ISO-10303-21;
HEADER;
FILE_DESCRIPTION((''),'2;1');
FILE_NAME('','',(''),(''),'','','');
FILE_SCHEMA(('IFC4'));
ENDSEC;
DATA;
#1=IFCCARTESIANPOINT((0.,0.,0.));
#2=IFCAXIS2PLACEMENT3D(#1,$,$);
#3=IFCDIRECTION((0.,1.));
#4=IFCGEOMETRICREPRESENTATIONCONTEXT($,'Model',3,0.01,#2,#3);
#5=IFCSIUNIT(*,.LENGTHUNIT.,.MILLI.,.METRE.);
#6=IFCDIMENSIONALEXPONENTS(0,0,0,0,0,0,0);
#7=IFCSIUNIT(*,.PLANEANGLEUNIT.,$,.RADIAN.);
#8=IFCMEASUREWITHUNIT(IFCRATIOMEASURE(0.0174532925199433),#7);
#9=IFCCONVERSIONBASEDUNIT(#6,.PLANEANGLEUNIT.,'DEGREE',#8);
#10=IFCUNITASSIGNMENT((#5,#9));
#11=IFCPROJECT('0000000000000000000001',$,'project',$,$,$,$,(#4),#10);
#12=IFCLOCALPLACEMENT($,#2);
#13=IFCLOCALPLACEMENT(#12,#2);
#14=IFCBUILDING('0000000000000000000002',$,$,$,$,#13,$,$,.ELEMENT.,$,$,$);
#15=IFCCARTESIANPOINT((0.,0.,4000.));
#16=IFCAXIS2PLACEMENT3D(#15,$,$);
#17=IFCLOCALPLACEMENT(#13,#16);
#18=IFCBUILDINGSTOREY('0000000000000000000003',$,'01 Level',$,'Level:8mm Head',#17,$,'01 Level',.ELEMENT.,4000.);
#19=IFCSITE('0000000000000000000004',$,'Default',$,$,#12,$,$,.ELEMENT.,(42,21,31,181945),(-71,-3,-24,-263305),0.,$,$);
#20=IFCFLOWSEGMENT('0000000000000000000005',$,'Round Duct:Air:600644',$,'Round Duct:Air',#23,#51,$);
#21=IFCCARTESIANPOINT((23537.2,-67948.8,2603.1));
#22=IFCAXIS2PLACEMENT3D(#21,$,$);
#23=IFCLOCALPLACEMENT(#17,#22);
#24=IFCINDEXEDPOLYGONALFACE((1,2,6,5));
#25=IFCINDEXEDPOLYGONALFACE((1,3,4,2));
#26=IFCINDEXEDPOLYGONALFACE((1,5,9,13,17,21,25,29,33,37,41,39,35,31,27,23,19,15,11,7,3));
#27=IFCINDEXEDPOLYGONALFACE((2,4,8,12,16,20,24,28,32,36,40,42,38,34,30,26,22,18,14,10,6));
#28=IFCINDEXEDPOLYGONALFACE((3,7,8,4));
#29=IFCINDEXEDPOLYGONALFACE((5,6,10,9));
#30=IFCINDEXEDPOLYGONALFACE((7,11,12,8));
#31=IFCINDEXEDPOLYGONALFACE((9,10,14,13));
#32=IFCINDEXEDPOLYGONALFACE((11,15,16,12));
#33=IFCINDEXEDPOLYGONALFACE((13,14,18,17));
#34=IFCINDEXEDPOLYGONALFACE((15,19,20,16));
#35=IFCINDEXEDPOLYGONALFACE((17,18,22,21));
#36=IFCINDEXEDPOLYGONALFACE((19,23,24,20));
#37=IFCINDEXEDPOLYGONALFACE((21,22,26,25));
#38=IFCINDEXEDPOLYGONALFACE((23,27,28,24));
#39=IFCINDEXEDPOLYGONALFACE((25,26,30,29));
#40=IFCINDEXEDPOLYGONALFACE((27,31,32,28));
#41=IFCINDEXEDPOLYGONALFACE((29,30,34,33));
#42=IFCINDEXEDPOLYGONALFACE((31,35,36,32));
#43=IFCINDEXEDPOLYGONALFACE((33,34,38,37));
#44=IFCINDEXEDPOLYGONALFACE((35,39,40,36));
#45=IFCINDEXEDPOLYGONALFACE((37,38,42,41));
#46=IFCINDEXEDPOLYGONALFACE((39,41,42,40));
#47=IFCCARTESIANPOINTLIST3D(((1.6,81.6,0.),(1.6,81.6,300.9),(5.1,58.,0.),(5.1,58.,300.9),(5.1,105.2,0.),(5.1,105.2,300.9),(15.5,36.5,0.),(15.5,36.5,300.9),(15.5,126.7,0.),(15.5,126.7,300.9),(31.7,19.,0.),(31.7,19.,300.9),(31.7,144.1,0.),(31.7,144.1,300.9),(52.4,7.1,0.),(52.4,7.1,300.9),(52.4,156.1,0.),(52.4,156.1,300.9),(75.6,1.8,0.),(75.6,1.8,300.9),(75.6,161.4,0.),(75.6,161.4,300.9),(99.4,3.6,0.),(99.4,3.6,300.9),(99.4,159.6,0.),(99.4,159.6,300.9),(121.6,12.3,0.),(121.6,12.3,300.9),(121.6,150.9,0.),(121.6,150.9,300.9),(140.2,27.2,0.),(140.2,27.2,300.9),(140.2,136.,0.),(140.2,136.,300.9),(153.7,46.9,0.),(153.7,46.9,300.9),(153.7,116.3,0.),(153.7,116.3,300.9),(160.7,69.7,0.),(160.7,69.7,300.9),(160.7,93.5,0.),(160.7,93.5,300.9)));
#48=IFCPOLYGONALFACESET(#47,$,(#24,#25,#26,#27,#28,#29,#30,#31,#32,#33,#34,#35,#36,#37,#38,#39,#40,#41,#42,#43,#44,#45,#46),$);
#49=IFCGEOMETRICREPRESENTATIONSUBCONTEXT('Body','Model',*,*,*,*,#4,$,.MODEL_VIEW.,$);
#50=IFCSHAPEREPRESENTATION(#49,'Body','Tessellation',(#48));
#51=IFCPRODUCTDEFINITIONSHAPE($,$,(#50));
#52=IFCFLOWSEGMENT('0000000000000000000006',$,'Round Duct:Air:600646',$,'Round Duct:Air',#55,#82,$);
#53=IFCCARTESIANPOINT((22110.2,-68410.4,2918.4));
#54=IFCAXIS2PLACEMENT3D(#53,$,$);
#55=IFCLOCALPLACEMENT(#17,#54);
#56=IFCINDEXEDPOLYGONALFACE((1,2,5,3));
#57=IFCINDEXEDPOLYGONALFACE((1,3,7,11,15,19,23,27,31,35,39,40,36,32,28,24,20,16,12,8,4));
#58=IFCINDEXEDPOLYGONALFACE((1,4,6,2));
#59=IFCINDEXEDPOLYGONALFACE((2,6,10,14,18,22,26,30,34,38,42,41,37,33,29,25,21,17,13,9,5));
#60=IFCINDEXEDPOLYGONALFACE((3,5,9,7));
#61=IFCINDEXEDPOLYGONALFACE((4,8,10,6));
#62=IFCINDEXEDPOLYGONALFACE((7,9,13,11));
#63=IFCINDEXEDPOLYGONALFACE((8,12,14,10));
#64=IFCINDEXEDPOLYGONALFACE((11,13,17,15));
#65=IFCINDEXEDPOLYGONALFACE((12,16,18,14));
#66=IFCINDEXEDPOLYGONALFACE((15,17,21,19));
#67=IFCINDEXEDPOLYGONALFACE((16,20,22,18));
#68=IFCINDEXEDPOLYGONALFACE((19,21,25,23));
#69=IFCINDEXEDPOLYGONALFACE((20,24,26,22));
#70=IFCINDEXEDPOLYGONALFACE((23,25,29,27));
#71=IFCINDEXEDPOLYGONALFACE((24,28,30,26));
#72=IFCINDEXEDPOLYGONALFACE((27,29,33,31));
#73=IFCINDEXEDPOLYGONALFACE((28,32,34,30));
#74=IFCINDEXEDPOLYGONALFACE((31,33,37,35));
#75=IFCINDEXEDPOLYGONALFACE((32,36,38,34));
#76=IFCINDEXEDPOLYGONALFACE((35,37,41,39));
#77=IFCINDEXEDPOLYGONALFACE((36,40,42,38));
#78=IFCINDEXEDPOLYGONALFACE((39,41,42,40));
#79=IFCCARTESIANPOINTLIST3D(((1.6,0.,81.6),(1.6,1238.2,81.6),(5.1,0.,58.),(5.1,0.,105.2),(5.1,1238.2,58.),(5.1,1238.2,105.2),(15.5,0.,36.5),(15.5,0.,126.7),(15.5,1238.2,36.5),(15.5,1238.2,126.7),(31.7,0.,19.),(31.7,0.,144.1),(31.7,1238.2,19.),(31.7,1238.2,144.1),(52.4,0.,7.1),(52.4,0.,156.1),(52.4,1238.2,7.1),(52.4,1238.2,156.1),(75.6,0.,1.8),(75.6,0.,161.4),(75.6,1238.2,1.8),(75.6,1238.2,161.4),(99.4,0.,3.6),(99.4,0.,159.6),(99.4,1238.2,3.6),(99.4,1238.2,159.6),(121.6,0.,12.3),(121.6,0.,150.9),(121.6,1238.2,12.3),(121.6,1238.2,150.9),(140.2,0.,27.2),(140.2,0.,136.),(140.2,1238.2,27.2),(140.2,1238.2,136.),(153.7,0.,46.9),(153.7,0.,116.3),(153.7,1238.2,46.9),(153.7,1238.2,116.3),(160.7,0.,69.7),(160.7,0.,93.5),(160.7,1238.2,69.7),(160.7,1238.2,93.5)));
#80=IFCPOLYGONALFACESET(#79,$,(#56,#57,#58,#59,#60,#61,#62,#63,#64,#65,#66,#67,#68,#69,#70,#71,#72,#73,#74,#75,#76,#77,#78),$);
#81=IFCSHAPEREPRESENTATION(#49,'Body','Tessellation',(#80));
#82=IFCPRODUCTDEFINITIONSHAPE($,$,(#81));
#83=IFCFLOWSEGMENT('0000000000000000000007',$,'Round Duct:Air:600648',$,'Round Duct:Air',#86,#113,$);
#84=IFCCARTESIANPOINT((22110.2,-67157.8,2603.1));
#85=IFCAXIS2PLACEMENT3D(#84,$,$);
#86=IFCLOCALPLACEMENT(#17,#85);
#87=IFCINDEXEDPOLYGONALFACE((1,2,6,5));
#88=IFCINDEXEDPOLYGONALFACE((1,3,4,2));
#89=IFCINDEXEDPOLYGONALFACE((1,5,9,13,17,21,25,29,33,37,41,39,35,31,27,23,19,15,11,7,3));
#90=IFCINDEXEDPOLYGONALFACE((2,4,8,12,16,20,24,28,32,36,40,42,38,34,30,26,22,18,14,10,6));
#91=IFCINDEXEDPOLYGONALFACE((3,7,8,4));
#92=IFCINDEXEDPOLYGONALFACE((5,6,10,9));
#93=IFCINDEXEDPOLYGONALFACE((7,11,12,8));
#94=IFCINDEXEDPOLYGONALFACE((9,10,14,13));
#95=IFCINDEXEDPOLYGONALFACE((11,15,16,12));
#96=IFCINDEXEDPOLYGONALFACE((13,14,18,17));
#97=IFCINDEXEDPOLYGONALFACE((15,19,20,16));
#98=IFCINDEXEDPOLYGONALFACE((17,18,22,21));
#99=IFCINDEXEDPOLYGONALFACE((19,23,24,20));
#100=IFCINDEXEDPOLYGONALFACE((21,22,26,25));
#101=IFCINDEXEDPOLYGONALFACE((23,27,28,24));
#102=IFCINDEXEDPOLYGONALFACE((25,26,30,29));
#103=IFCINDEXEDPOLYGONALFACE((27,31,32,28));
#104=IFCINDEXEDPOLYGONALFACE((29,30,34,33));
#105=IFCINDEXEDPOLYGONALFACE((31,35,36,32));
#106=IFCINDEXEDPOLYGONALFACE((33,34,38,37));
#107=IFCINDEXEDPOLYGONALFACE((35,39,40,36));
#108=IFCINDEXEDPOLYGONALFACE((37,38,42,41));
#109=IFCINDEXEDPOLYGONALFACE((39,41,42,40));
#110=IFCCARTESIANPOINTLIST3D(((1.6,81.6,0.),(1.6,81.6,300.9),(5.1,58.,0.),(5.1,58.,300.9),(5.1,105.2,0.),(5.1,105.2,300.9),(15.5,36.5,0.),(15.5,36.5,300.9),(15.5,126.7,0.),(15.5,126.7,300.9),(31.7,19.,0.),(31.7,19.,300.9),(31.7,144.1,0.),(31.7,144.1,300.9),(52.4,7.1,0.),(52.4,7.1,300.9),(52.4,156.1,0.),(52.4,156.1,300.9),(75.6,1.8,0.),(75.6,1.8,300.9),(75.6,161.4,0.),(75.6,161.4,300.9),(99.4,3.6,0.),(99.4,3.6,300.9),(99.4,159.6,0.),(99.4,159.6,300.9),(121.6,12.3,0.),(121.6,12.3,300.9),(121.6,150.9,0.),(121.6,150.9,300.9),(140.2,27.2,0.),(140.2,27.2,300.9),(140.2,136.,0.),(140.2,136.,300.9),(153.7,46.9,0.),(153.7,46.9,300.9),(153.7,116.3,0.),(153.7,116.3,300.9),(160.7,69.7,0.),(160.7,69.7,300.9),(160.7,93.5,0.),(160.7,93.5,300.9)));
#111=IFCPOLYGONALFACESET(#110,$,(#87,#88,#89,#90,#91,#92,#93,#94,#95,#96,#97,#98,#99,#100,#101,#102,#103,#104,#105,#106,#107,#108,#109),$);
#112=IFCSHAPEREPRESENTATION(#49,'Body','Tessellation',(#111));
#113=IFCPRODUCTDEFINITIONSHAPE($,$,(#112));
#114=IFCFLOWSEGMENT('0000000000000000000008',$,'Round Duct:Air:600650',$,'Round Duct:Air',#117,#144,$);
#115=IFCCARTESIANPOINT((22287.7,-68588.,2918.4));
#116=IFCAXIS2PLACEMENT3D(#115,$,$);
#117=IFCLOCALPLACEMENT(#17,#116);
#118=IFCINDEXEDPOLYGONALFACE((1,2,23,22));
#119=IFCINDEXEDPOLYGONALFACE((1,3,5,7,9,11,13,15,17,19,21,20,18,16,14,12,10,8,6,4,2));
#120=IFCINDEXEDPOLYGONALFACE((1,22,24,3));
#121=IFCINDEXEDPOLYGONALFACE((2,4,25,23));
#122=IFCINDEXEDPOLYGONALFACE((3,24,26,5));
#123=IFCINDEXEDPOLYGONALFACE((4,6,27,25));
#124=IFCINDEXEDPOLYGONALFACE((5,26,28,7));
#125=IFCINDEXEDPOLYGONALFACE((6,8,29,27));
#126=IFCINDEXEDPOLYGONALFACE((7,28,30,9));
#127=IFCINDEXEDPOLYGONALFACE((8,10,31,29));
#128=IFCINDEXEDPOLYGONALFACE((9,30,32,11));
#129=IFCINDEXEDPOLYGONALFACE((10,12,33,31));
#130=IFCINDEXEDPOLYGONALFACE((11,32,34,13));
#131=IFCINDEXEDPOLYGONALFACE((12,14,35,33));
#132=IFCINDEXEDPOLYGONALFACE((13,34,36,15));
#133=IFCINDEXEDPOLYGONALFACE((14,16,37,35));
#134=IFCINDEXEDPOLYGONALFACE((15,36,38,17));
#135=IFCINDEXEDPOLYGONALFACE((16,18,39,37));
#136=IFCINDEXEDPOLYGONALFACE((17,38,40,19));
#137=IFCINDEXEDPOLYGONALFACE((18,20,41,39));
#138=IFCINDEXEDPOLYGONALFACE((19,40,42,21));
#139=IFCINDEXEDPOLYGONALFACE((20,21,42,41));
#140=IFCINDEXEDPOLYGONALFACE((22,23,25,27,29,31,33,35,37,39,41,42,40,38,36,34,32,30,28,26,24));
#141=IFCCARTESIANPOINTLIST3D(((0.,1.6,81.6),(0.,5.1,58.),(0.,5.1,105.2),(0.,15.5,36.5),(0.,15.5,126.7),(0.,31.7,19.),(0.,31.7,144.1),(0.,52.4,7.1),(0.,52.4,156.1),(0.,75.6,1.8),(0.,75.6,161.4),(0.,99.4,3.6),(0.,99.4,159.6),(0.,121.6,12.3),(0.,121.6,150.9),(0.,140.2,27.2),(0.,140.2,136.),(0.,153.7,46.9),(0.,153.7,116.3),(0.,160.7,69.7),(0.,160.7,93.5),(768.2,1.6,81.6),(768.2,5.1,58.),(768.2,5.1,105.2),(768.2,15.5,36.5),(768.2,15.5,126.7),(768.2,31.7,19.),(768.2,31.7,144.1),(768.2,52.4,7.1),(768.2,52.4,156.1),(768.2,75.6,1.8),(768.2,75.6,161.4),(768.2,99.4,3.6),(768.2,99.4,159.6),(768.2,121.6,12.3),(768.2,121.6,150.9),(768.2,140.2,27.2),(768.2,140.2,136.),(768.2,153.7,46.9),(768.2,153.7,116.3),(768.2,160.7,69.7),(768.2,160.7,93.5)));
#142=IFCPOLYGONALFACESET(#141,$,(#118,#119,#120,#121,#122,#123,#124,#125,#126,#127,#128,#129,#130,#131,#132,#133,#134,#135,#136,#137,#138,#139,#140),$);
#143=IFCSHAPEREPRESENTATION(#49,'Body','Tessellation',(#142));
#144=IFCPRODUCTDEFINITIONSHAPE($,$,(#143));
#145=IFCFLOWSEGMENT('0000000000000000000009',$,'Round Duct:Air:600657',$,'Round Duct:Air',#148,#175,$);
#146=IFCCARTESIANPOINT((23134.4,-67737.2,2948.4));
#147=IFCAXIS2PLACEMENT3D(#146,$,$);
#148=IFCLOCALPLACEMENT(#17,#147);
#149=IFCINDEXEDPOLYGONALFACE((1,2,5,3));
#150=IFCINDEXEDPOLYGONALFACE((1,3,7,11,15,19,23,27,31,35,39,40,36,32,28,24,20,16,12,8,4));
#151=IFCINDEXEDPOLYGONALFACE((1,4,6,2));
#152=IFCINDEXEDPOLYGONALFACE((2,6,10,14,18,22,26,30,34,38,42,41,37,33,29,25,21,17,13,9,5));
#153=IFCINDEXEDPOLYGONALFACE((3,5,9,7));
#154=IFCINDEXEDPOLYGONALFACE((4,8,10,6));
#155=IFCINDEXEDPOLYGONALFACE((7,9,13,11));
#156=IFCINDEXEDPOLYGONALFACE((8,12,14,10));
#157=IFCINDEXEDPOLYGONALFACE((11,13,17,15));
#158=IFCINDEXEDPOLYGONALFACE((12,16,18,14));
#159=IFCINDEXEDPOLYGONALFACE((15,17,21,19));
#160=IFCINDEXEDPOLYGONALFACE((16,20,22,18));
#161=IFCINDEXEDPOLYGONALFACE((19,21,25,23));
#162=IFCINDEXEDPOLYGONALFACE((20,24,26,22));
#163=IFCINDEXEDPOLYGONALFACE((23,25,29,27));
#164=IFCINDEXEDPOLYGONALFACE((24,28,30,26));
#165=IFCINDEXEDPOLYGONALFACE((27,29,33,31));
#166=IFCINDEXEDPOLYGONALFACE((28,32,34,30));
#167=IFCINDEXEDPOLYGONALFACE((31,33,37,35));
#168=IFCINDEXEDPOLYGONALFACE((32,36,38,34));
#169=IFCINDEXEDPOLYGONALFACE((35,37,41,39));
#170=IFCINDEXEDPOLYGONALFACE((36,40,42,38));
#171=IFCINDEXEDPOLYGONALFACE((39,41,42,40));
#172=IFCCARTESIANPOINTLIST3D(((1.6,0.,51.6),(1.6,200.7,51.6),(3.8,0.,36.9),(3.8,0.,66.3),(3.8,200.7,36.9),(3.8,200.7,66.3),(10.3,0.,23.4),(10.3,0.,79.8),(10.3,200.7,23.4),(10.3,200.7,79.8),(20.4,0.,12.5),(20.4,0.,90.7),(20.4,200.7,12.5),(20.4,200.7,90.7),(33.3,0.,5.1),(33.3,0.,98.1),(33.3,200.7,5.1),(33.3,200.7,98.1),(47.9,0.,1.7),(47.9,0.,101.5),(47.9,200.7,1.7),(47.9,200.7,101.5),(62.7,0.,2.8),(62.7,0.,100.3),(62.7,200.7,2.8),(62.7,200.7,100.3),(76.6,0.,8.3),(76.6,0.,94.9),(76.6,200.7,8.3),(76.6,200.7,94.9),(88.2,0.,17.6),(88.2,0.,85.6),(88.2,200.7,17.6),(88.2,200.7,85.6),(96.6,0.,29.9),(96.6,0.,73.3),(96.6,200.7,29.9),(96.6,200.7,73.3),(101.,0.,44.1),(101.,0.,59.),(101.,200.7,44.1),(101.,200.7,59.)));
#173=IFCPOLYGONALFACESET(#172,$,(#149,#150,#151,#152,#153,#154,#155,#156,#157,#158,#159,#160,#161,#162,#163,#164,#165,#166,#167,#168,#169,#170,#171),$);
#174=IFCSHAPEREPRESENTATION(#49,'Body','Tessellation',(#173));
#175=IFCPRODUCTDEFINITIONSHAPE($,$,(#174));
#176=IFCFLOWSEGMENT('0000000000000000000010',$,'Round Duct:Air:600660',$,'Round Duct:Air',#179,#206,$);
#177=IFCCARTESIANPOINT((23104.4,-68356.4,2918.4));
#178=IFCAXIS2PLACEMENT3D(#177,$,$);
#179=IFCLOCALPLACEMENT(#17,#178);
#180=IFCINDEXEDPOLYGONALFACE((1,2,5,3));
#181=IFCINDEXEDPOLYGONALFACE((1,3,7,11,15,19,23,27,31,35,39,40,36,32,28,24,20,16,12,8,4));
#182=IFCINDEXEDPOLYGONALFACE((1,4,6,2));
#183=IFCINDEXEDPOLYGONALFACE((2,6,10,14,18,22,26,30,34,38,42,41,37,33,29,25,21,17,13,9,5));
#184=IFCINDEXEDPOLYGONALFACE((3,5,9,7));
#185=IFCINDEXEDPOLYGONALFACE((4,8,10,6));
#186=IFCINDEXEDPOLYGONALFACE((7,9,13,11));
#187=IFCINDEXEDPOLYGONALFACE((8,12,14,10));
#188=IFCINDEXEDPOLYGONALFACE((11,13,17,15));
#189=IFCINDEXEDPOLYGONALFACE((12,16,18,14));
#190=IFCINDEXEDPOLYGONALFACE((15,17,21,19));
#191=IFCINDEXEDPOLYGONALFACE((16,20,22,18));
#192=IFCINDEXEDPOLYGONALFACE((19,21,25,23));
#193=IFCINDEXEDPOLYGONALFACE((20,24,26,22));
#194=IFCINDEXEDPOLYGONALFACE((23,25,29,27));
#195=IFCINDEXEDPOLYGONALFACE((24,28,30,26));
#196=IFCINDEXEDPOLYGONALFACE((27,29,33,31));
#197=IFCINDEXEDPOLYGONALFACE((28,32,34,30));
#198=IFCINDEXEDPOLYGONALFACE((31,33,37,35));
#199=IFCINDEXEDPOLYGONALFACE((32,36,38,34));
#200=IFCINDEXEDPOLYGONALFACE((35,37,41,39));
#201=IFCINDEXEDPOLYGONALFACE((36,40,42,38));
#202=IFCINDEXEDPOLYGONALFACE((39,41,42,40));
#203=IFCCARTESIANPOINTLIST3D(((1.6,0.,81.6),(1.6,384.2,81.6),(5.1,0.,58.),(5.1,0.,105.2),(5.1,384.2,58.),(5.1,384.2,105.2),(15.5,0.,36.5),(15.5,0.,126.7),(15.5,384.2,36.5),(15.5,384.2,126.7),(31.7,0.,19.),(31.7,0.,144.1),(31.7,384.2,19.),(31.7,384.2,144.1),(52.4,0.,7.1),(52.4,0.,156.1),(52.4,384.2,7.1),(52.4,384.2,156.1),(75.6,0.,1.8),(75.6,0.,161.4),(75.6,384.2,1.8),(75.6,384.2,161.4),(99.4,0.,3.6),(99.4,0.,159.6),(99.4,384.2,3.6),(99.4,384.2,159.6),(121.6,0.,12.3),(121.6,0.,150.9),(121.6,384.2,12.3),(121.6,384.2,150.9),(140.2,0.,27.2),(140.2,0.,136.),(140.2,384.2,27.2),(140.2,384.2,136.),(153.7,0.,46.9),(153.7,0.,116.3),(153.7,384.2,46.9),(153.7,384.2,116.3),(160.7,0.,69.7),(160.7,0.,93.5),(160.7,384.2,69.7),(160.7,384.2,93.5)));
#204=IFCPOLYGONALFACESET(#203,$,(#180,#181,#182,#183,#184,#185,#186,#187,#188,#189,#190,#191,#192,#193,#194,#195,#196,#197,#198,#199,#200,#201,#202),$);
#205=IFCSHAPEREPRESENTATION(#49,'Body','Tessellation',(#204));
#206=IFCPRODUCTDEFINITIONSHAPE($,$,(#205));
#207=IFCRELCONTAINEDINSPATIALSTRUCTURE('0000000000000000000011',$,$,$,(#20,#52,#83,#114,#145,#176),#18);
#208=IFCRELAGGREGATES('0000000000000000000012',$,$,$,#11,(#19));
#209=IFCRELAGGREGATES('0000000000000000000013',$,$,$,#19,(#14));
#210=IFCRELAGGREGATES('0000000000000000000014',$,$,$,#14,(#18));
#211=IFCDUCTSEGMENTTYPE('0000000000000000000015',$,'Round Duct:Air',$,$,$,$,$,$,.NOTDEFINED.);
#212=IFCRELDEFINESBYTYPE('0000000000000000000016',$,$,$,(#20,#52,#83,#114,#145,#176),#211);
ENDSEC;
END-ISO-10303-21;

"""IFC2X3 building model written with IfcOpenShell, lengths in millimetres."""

from ifc_helpers import new_model, entity, si_unit, converted_unit, direction, frame, frame_2d, origin, origin_2d_with_axis, place, context, subcontext, project, spatial, circle, extrude, type_object, element, save


model = new_model("IFC2X3")

# Units and contexts
model_context = context("Model", 3, precision=0.01, world=origin(), true_north=direction((0.0, 1.0)))
body_context = subcontext(model_context, "Body", "Model", "MODEL_VIEW")
ifc_project = project(units=[si_unit("LENGTHUNIT", "METRE", prefix="MILLI"), converted_unit("PLANEANGLEUNIT", "DEGREE", entity("IfcRatioMeasure", 0.0174532925199433), si_unit("PLANEANGLEUNIT", "RADIAN"), dimensions=[0, 0, 0, 0, 0, 0, 0])], contexts=[model_context])

# Site, building, storey
site_placement = place(None, origin())
site = spatial("IfcSite", under=ifc_project, at=site_placement, Name="Default", CompositionType="ELEMENT", RefLatitude=(42, 21, 31, 181945), RefLongitude=(-71, -3, -24, -263305), RefElevation=0.0)
building_placement = place(site_placement, origin())
building = spatial("IfcBuilding", under=site, at=building_placement, CompositionType="ELEMENT")
storey_placement = place(building_placement, frame((0.0, 0.0, 4000.0)))
storey = spatial("IfcBuildingStorey", under=building, at=storey_placement, Name="01 Level", ObjectType="Level:8mm Head", LongName="01 Level", CompositionType="ELEMENT", Elevation=4000.0)

# Flow segments
duct_segment_type_1 = type_object("IfcDuctSegmentType", Name="Round Duct:Air", PredefinedType="NOTDEFINED")
flow_segment_1_placement = place(storey_placement, frame((23537.2, -67948.8, 2603.1)))
element("IfcFlowSegment", 1, at=flow_segment_1_placement, inside=storey, type_object=duct_segment_type_1, Name="Round Duct:Air:600644", ObjectType="Round Duct:Air", context=body_context, shape_type="SweptSolid", body=[
    extrude(circle(Radius=80.0, at=origin_2d_with_axis()), frame((81.6, 81.6, 0.0), z_axis=(0.0, 0.0, 1.0), x_axis=(-1.0, 0.0, 0.0)), (0.0, 0.0, 1.0), 300.9),
])
flow_segment_2_placement = place(storey_placement, frame((22110.2, -68410.4, 2918.4)))
element("IfcFlowSegment", 2, at=flow_segment_2_placement, inside=storey, type_object=duct_segment_type_1, Name="Round Duct:Air:600646", ObjectType="Round Duct:Air", context=body_context, shape_type="SweptSolid", body=[
    extrude(circle(Radius=80.0, at=frame_2d((0.0, 0.0), x_axis=(1.0, 0.0))), frame((81.6, 0.0, 81.6), z_axis=(0.0, 1.0, 0.0), x_axis=(-1.0, 0.0, 0.0)), (0.0, 0.0, 1.0), 1238.2),
])
flow_segment_3_placement = place(storey_placement, frame((22110.2, -67157.8, 2603.1)))
element("IfcFlowSegment", 3, at=flow_segment_3_placement, inside=storey, type_object=duct_segment_type_1, Name="Round Duct:Air:600648", ObjectType="Round Duct:Air", context=body_context, shape_type="SweptSolid", body=[
    extrude(circle(Radius=80.0, at=origin_2d_with_axis()), frame((81.6, 81.6, 0.0), z_axis=(0.0, 0.0, 1.0), x_axis=(-1.0, 0.0, 0.0)), (0.0, 0.0, 1.0), 300.9),
])
flow_segment_4_placement = place(storey_placement, frame((22287.7, -68588.0, 2918.4)))
element("IfcFlowSegment", 4, at=flow_segment_4_placement, inside=storey, type_object=duct_segment_type_1, Name="Round Duct:Air:600650", ObjectType="Round Duct:Air", context=body_context, shape_type="SweptSolid", body=[
    extrude(circle(Radius=80.0, at=origin_2d_with_axis()), frame((0.0, 81.6, 81.6), z_axis=(1.0, 0.0, 0.0), x_axis=(0.0, -1.0, 0.0)), (0.0, 0.0, 1.0), 768.2),
])
flow_segment_5_placement = place(storey_placement, frame((23134.4, -67737.2, 2948.4)))
element("IfcFlowSegment", 5, at=flow_segment_5_placement, inside=storey, type_object=duct_segment_type_1, Name="Round Duct:Air:600657", ObjectType="Round Duct:Air", context=body_context, shape_type="SweptSolid", body=[
    extrude(circle(Radius=50.0, at=origin_2d_with_axis()), frame((51.6, 0.0, 51.6), z_axis=(0.0, 1.0, 0.0), x_axis=(-1.0, 0.0, 0.0)), (0.0, 0.0, 1.0), 200.7),
])
flow_segment_6_placement = place(storey_placement, frame((23104.4, -68356.4, 2918.4)))
element("IfcFlowSegment", 6, at=flow_segment_6_placement, inside=storey, type_object=duct_segment_type_1, Name="Round Duct:Air:600660", ObjectType="Round Duct:Air", context=body_context, shape_type="SweptSolid", body=[
    extrude(circle(Radius=80.0, at=origin_2d_with_axis()), frame((81.6, 0.0, 81.6), z_axis=(0.0, 1.0, 0.0), x_axis=(-1.0, 0.0, 0.0)), (0.0, 0.0, 1.0), 384.2),
])

save(model, "model.ifc")
